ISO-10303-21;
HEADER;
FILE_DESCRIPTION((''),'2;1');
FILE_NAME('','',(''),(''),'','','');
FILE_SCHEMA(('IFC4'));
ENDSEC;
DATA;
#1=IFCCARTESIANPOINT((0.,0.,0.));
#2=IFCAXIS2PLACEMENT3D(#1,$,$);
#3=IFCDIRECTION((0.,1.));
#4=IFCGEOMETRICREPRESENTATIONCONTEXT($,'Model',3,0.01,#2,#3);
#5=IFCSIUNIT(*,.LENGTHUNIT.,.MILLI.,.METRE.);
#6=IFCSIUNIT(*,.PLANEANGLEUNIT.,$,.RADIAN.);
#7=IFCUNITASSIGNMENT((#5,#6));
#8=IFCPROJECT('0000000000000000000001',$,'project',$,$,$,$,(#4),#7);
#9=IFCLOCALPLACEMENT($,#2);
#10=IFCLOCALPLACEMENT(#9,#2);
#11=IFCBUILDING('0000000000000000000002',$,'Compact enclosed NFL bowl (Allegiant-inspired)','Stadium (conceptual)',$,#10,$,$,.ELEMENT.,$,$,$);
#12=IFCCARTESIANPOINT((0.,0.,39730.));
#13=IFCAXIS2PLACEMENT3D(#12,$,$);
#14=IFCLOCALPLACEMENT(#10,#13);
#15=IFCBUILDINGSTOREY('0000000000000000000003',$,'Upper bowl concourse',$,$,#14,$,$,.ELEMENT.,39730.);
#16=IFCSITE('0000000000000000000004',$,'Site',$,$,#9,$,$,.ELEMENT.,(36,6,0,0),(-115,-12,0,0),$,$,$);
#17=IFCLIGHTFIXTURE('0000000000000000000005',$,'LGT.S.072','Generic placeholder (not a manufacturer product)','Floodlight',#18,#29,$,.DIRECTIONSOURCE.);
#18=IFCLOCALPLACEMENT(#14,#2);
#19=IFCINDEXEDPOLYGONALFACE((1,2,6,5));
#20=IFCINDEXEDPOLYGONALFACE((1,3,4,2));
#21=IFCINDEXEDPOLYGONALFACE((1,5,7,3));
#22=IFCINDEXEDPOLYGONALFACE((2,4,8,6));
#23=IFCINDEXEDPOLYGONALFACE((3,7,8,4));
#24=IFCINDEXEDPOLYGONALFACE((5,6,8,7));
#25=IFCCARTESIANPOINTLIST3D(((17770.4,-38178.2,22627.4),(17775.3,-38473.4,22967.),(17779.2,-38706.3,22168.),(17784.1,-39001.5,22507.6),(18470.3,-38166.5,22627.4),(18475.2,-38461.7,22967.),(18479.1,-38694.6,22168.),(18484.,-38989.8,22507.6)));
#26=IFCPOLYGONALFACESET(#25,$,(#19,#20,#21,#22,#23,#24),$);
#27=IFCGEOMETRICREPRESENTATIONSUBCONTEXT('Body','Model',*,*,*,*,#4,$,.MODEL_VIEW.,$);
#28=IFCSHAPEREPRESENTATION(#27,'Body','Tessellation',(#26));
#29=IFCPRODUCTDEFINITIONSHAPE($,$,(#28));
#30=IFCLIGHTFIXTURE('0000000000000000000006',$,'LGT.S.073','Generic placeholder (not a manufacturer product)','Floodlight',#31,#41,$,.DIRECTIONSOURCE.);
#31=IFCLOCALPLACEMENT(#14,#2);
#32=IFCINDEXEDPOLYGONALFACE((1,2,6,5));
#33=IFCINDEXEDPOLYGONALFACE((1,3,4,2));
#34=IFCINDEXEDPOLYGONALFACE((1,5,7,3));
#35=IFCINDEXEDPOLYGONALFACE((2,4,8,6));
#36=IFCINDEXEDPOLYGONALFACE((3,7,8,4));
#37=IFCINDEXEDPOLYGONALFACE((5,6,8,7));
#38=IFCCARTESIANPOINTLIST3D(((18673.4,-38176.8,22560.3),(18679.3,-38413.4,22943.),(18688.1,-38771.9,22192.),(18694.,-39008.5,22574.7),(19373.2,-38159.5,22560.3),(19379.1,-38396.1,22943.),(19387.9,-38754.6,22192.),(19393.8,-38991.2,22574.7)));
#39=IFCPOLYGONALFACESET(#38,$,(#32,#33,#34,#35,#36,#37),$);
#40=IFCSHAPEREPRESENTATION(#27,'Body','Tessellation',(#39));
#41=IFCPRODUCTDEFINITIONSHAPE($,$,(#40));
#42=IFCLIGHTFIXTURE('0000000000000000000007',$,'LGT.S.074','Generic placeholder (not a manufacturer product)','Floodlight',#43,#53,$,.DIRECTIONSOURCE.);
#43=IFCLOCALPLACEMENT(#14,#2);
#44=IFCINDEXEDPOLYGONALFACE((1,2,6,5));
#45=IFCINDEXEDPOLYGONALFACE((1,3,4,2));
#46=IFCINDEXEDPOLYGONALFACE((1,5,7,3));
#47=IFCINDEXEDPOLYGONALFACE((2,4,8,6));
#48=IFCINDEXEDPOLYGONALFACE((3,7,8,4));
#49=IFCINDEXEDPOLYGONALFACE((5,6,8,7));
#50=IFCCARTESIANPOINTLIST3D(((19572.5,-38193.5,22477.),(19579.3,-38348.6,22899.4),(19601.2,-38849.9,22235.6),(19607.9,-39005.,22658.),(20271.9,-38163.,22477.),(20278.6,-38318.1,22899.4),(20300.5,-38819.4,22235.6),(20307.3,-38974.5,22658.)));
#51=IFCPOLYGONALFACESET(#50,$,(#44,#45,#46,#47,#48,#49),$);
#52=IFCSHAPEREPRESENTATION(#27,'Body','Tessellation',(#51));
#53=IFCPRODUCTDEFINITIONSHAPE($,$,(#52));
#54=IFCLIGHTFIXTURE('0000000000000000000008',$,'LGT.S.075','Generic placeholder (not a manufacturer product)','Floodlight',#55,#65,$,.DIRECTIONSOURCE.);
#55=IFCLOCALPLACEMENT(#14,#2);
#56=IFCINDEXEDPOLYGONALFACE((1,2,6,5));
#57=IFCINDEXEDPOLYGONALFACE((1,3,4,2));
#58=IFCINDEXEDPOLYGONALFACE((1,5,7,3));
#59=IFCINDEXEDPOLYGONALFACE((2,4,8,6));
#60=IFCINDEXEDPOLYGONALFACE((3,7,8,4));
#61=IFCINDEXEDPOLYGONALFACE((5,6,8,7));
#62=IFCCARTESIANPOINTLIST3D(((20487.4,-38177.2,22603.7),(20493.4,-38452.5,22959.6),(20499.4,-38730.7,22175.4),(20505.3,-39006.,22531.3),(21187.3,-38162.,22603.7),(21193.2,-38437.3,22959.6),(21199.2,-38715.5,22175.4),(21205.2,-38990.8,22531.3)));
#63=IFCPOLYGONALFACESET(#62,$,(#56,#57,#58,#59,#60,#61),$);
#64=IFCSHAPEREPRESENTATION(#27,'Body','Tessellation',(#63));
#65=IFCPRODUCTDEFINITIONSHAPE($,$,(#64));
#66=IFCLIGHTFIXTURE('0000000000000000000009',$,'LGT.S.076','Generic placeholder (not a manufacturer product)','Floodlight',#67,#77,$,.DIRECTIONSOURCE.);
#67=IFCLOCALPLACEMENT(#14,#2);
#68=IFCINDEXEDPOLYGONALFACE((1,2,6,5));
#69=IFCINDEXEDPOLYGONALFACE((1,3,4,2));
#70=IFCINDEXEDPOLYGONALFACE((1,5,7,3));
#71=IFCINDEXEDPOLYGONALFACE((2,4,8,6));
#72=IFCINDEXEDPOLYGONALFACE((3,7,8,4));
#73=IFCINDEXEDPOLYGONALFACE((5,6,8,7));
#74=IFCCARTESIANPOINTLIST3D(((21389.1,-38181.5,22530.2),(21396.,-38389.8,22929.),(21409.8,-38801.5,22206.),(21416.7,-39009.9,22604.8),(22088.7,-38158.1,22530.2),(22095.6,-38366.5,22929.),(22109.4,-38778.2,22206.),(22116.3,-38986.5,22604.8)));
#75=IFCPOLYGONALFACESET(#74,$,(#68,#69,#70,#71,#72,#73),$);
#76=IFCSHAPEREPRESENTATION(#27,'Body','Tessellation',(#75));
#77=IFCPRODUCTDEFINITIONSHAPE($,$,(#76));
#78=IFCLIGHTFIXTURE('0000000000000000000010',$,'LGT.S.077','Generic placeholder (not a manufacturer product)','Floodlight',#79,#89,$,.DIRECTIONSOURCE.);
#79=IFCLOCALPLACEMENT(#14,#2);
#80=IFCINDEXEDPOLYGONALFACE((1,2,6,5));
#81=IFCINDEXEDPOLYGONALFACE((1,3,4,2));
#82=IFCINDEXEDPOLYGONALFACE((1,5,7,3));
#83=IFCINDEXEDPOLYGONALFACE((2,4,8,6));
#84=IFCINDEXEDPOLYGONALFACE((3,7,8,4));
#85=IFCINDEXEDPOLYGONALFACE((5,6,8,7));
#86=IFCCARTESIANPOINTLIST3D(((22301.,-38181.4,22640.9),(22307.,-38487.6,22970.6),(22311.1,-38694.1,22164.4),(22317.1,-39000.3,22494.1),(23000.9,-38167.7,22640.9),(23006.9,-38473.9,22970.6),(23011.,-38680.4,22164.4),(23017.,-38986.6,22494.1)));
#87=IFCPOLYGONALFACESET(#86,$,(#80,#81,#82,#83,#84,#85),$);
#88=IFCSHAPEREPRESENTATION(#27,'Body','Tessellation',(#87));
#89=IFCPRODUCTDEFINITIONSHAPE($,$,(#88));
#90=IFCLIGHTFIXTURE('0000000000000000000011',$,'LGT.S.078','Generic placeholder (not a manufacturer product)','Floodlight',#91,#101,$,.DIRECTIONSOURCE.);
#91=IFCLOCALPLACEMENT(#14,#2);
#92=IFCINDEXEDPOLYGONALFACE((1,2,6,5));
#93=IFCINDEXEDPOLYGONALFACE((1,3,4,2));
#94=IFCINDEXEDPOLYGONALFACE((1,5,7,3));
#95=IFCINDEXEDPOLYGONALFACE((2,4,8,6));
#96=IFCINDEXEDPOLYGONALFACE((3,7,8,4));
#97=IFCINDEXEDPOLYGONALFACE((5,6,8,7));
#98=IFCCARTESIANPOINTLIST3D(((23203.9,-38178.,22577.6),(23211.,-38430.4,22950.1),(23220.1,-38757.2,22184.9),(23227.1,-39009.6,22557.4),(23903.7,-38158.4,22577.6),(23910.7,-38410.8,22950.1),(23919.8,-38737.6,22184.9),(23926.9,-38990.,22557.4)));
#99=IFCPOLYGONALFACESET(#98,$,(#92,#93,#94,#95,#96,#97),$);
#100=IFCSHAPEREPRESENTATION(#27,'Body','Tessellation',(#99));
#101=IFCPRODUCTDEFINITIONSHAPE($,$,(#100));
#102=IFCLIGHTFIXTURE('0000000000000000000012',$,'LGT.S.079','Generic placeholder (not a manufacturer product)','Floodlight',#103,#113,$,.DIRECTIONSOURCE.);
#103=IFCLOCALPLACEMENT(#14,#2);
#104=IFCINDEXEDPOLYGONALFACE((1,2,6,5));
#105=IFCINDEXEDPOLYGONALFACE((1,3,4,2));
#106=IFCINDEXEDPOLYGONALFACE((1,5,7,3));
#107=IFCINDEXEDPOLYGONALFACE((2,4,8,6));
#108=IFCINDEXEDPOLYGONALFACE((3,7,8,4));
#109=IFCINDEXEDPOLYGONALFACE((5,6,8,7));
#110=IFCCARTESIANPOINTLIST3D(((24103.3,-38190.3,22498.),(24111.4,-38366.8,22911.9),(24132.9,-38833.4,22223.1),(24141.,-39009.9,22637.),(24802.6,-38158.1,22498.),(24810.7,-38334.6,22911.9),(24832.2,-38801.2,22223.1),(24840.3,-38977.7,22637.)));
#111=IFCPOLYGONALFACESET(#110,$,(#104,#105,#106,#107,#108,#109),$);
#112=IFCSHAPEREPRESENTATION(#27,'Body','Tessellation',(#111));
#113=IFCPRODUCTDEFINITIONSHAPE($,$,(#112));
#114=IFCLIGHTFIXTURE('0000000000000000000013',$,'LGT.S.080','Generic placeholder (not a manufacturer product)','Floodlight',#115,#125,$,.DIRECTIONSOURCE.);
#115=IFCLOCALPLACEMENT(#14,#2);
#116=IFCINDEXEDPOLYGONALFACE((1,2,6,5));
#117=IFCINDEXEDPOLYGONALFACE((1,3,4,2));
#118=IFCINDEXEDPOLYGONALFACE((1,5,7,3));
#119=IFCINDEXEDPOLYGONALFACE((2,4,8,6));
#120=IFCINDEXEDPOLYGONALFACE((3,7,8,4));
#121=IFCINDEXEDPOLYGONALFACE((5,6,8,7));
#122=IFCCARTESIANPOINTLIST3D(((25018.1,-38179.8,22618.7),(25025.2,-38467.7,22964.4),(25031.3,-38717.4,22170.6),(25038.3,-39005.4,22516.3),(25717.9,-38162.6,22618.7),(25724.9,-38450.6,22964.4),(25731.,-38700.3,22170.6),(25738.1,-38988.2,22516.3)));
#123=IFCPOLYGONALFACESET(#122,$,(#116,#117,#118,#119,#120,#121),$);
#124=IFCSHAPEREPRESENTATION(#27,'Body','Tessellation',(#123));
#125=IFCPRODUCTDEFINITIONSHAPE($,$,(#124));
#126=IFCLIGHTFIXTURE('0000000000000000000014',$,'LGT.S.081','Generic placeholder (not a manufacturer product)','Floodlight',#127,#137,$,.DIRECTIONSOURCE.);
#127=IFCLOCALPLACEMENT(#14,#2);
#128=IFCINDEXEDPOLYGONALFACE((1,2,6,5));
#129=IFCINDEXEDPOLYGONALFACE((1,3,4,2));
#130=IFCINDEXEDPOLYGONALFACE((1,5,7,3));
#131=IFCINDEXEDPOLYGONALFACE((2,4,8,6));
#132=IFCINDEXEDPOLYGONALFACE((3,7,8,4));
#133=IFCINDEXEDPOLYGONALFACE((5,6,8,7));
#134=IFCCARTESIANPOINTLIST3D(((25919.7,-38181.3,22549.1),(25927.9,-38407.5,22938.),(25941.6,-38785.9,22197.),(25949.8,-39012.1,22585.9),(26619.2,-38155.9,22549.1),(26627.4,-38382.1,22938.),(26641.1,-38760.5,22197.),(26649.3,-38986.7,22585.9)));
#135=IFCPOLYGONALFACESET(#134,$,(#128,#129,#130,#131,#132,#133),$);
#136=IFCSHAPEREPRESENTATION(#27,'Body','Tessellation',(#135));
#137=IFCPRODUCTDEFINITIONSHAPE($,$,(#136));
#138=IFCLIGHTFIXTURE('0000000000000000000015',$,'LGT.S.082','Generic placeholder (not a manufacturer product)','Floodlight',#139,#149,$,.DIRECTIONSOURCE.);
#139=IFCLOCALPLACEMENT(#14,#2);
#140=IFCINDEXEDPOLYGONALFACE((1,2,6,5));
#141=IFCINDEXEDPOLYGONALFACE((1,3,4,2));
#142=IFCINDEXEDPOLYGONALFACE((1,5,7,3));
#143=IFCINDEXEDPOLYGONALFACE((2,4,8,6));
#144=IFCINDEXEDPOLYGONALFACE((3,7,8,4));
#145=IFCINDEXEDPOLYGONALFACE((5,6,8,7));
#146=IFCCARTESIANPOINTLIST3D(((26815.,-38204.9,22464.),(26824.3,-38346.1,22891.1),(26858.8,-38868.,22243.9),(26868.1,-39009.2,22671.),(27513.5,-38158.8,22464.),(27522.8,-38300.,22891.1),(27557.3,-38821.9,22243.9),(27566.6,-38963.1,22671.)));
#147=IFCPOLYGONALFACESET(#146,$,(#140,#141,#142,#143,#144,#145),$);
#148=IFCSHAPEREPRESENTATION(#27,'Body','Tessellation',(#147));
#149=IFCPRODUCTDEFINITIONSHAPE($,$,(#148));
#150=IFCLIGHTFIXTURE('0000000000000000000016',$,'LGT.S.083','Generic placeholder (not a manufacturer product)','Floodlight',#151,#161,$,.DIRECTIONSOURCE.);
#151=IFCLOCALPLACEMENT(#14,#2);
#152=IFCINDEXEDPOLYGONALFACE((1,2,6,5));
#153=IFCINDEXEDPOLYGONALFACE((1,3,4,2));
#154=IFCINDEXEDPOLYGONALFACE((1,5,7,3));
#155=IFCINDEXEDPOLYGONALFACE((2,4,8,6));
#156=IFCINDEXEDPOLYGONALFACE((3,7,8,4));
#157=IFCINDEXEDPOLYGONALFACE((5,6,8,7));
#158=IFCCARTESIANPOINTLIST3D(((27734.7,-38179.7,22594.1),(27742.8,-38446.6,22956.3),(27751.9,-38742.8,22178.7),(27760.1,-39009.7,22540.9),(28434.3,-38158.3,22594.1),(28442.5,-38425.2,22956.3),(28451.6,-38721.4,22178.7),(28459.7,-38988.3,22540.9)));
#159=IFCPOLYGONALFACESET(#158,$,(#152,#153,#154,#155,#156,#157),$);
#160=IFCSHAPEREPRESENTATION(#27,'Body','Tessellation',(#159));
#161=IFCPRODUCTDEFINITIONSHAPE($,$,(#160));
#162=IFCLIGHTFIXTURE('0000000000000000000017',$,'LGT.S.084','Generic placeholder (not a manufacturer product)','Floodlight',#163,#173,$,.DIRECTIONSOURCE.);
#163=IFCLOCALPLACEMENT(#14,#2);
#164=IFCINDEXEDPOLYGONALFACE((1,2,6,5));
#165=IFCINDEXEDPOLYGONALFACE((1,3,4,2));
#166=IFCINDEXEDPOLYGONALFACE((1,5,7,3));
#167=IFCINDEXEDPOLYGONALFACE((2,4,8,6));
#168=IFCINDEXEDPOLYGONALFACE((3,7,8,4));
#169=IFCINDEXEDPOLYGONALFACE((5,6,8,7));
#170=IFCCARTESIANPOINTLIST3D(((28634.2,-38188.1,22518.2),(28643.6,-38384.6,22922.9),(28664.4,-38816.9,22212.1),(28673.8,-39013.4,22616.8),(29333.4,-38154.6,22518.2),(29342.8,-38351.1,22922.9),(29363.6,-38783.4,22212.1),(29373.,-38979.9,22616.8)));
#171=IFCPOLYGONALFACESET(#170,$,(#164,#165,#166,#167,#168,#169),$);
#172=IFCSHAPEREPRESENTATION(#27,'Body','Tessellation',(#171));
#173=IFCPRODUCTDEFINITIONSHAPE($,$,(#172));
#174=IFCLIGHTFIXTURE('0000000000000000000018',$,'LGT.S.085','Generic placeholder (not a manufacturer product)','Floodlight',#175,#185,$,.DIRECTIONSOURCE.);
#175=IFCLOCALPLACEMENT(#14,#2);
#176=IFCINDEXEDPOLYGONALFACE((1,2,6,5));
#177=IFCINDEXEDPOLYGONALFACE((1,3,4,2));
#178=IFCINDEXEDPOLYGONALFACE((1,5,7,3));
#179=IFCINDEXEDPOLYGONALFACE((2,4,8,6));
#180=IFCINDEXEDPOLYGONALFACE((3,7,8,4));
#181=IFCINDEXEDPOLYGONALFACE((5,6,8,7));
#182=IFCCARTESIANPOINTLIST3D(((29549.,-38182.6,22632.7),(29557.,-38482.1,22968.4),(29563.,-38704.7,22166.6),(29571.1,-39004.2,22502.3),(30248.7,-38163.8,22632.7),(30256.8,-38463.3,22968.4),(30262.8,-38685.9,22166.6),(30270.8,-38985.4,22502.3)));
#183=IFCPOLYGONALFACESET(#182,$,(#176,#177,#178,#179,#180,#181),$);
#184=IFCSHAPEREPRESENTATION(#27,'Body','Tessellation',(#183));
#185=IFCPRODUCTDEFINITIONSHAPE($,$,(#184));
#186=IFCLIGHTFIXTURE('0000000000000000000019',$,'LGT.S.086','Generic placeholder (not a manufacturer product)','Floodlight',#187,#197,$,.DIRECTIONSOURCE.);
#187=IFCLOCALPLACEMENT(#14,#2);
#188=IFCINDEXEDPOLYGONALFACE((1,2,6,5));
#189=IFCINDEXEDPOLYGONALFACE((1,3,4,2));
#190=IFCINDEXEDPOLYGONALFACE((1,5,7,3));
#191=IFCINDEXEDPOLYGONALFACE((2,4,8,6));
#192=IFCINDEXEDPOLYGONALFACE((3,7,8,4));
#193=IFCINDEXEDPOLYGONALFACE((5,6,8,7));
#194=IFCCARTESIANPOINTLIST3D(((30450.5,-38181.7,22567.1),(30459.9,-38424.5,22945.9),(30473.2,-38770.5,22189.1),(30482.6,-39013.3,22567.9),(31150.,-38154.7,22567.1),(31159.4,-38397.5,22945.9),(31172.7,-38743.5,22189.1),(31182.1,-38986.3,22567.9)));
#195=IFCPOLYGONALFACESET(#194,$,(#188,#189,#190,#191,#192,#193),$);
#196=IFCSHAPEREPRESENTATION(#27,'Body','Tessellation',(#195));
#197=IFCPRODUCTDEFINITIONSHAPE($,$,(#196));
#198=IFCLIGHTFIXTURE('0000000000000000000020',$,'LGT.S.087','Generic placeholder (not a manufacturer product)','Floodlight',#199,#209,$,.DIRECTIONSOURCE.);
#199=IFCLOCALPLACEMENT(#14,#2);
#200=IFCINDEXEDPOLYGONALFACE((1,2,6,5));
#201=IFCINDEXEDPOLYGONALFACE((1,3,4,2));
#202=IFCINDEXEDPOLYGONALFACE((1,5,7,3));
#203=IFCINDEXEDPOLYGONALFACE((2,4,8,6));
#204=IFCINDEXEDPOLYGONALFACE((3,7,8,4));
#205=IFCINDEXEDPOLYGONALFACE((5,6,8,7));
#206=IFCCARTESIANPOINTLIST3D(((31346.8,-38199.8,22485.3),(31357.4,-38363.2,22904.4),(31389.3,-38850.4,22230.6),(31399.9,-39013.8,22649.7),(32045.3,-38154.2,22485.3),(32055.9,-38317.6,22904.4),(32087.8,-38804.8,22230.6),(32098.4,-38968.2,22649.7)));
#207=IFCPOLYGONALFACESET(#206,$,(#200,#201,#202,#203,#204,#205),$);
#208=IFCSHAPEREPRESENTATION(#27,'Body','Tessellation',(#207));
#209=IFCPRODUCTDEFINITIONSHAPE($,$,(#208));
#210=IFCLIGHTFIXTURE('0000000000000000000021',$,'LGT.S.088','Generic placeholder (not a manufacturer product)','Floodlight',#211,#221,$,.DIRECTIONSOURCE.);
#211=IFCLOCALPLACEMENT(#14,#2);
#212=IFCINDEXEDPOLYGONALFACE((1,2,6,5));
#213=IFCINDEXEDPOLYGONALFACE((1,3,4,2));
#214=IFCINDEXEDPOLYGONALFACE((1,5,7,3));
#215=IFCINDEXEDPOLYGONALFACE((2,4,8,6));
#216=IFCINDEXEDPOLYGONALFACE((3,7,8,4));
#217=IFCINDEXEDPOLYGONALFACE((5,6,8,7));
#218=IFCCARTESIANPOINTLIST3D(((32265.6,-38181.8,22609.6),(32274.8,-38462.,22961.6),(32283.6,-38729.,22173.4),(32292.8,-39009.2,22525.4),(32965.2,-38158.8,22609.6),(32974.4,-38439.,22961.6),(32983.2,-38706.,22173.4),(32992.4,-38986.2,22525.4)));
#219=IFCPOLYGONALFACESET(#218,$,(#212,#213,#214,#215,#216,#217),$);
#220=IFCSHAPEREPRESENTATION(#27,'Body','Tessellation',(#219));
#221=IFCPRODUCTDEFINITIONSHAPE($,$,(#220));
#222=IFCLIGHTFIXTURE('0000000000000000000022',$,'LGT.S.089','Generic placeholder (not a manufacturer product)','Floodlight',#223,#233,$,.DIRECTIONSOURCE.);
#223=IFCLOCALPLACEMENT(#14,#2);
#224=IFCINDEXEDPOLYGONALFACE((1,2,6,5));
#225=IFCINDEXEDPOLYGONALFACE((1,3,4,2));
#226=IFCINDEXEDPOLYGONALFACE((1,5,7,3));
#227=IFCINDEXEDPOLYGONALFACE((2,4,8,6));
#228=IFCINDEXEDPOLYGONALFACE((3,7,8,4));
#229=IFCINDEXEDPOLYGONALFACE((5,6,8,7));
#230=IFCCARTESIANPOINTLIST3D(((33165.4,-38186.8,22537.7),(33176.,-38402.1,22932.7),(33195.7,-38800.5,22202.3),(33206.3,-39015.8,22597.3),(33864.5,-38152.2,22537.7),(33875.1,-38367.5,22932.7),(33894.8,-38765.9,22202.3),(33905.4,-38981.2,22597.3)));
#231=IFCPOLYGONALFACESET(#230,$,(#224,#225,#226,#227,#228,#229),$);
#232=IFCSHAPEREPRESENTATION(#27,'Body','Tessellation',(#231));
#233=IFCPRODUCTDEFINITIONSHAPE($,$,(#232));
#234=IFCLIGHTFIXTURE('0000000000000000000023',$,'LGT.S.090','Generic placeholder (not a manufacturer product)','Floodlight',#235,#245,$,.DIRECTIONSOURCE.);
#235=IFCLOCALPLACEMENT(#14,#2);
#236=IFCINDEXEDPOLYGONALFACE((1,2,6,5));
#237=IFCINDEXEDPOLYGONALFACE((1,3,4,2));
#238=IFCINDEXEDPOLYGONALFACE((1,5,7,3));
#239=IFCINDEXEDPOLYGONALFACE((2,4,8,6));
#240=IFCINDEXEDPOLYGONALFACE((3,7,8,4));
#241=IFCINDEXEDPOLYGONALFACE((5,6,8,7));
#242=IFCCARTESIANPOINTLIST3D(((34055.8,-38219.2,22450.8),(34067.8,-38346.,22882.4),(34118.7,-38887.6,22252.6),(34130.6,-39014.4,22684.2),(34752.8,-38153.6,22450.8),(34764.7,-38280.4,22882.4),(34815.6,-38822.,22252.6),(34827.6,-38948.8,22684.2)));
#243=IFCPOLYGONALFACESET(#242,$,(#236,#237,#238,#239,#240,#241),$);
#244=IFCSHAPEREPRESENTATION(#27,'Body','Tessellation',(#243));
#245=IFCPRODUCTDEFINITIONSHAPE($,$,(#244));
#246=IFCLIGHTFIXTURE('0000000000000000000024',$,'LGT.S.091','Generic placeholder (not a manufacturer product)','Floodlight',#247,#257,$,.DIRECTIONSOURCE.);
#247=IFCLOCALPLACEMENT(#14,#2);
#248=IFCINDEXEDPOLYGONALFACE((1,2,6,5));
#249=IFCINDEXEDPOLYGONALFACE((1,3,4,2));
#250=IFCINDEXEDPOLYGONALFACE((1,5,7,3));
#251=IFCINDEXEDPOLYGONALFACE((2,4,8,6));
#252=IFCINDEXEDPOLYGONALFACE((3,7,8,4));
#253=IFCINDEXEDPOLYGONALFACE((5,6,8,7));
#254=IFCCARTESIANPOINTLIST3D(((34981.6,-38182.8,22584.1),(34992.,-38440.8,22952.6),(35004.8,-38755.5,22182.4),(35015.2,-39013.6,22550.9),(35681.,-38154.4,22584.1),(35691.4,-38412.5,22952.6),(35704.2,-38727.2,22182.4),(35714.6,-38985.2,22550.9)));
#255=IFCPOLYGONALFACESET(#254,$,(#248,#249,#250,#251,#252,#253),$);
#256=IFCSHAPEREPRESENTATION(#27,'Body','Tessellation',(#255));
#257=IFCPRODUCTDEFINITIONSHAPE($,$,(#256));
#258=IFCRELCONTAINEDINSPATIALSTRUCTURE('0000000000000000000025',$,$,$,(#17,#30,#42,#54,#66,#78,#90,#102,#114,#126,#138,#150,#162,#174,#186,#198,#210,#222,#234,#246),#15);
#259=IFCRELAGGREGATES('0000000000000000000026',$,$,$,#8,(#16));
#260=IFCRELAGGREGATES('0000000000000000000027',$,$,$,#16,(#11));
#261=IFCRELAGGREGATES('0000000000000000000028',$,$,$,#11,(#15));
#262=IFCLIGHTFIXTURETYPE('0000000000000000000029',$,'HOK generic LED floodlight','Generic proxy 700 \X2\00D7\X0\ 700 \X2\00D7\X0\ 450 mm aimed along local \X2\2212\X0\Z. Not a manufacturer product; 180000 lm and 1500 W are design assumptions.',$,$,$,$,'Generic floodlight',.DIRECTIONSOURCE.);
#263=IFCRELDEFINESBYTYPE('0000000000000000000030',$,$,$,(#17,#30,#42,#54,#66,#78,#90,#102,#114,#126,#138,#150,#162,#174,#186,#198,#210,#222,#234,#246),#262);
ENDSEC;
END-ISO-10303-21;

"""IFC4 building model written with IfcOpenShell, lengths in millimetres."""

from ifc_helpers import new_model, si_unit, direction, frame, origin, place, context, subcontext, project, spatial, rectangle, extrude, source, transform, mapped, type_object, type_shapes, element, save


model = new_model("IFC4")

# Units and contexts
model_context = context("Model", 3, precision=0.01, world=origin(), true_north=direction((0.0, 1.0)))
body_context = subcontext(model_context, "Body", "Model", "MODEL_VIEW")
ifc_project = project(units=[si_unit("LENGTHUNIT", "METRE", prefix="MILLI"), si_unit("PLANEANGLEUNIT", "RADIAN")], contexts=[model_context])

# Site, building, storey
site_placement = place(None, origin())
site = spatial("IfcSite", under=ifc_project, at=site_placement, Name="Site", CompositionType="ELEMENT", RefLatitude=(36, 6, 0, 0), RefLongitude=(-115, -12, 0, 0))
building_placement = place(site_placement, origin())
building = spatial("IfcBuilding", under=site, at=building_placement, Name="Compact enclosed NFL bowl (Allegiant-inspired)", Description="Stadium (conceptual)", CompositionType="ELEMENT")
storey_placement = place(building_placement, frame((0.0, 0.0, 39730.0)))
storey = spatial("IfcBuildingStorey", under=building, at=storey_placement, Name="Upper bowl concourse", CompositionType="ELEMENT", Elevation=39730.0)

# Light fixtures
light_fixture_type = type_object("IfcLightFixtureType", Name="HOK generic LED floodlight", Description="Generic proxy 700 × 700 × 450 mm aimed along local −Z. Not a manufacturer product; 180000 lm and 1500 W are design assumptions.", ElementType="Generic floodlight", PredefinedType="DIRECTIONSOURCE")
shared_shape = source(origin(), body_context, "Body", "SweptSolid", [
    extrude(rectangle(XDim=700.0, YDim=700.0), frame((0.0, 0.0, -225.0)), (0.0, 0.0, 1.0), 450.0),
])
type_shapes(light_fixture_type, [shared_shape])
for number, where, z_axis, x_axis, name in (
    (1, (18127.2, -38584.0, 22567.5), (0.010978, -0.656111, 0.754584), (0.99986, 0.01673, 0.0), "LGT.S.072"),
    (2, (19033.6, -38584.0, 22567.5), (0.012992, -0.525869, 0.850466), (0.999695, 0.024698, 0.0), "LGT.S.073"),
    (3, (19939.9, -38584.0, 22567.5), (0.015022, -0.344623, 0.938621), (0.999051, 0.043547, 0.0), "LGT.S.074"),
    (4, (20846.3, -38584.0, 22567.5), (0.013233, -0.611807, 0.790896), (0.999766, 0.021624, 0.0), "LGT.S.075"),
    (5, (21752.7, -38584.0, 22567.5), (0.015473, -0.462965, 0.886242), (0.999442, 0.033402, 0.0), "LGT.S.076"),
    (6, (22659.0, -38584.0, 22567.5), (0.013324, -0.680478, 0.732647), (0.999808, 0.019577, 0.0), "LGT.S.077"),
    (7, (23565.4, -38584.0, 22567.5), (0.015656, -0.560895, 0.827739), (0.999611, 0.027901, 0.0), "LGT.S.078"),
    (8, (24471.8, -38584.0, 22567.5), (0.018064, -0.392208, 0.919699), (0.998941, 0.046008, 0.0), "LGT.S.079"),
    (9, (25378.1, -38584.0, 22567.5), (0.015649, -0.639889, 0.768308), (0.999701, 0.024449, 0.0), "LGT.S.080"),
    (10, (26284.5, -38584.0, 22567.5), (0.018232, -0.502724, 0.864255), (0.999343, 0.036243, 0.0), "LGT.S.081"),
    (11, (27190.8, -38584.0, 22567.5), (0.020716, -0.31375, 0.94928), (0.997827, 0.065885, 0.0), "LGT.S.082"),
    (12, (28097.2, -38584.0, 22567.5), (0.018151, -0.59314, 0.804895), (0.999532, 0.030587, 0.0), "LGT.S.083"),
    (13, (29003.6, -38584.0, 22567.5), (0.020934, -0.436831, 0.8993), (0.998854, 0.047868, 0.0), "LGT.S.084"),
    (14, (29909.9, -38584.0, 22567.5), (0.01791, -0.665615, 0.746081), (0.999638, 0.026898, 0.0), "LGT.S.085"),
    (15, (30816.3, -38584.0, 22567.5), (0.020818, -0.539521, 0.841715), (0.999256, 0.038558, 0.0), "LGT.S.086"),
    (16, (31722.6, -38584.0, 22567.5), (0.023715, -0.363087, 0.931453), (0.997874, 0.065177, 0.0), "LGT.S.087"),
    (17, (32629.0, -38584.0, 22567.5), (0.020483, -0.622755, 0.782149), (0.99946, 0.032873, 0.0), "LGT.S.088"),
    (18, (33535.4, -38584.0, 22567.5), (0.023627, -0.478437, 0.877804), (0.998783, 0.049323, 0.0), "LGT.S.089"),
    (19, (34441.7, -38584.0, 22567.5), (0.026512, -0.281848, 0.959093), (0.995605, 0.093652, 0.0), "LGT.S.090"),
    (20, (35348.1, -38584.0, 22567.5), (0.023233, -0.573457, 0.818906), (0.99918, 0.04048, 0.0), "LGT.S.091"),
):
    element("IfcLightFixture", number, at=place(storey_placement, frame(where, z_axis=z_axis, x_axis=x_axis)), inside=storey, type_object=light_fixture_type, Name=name, Description="Generic placeholder (not a manufacturer product)", ObjectType="Floodlight", PredefinedType="DIRECTIONSOURCE", context=body_context, shape_type="MappedRepresentation", body=[
        mapped(shared_shape, transform((0.0, 0.0, 0.0))),
    ])

save(model, "model.ifc")
